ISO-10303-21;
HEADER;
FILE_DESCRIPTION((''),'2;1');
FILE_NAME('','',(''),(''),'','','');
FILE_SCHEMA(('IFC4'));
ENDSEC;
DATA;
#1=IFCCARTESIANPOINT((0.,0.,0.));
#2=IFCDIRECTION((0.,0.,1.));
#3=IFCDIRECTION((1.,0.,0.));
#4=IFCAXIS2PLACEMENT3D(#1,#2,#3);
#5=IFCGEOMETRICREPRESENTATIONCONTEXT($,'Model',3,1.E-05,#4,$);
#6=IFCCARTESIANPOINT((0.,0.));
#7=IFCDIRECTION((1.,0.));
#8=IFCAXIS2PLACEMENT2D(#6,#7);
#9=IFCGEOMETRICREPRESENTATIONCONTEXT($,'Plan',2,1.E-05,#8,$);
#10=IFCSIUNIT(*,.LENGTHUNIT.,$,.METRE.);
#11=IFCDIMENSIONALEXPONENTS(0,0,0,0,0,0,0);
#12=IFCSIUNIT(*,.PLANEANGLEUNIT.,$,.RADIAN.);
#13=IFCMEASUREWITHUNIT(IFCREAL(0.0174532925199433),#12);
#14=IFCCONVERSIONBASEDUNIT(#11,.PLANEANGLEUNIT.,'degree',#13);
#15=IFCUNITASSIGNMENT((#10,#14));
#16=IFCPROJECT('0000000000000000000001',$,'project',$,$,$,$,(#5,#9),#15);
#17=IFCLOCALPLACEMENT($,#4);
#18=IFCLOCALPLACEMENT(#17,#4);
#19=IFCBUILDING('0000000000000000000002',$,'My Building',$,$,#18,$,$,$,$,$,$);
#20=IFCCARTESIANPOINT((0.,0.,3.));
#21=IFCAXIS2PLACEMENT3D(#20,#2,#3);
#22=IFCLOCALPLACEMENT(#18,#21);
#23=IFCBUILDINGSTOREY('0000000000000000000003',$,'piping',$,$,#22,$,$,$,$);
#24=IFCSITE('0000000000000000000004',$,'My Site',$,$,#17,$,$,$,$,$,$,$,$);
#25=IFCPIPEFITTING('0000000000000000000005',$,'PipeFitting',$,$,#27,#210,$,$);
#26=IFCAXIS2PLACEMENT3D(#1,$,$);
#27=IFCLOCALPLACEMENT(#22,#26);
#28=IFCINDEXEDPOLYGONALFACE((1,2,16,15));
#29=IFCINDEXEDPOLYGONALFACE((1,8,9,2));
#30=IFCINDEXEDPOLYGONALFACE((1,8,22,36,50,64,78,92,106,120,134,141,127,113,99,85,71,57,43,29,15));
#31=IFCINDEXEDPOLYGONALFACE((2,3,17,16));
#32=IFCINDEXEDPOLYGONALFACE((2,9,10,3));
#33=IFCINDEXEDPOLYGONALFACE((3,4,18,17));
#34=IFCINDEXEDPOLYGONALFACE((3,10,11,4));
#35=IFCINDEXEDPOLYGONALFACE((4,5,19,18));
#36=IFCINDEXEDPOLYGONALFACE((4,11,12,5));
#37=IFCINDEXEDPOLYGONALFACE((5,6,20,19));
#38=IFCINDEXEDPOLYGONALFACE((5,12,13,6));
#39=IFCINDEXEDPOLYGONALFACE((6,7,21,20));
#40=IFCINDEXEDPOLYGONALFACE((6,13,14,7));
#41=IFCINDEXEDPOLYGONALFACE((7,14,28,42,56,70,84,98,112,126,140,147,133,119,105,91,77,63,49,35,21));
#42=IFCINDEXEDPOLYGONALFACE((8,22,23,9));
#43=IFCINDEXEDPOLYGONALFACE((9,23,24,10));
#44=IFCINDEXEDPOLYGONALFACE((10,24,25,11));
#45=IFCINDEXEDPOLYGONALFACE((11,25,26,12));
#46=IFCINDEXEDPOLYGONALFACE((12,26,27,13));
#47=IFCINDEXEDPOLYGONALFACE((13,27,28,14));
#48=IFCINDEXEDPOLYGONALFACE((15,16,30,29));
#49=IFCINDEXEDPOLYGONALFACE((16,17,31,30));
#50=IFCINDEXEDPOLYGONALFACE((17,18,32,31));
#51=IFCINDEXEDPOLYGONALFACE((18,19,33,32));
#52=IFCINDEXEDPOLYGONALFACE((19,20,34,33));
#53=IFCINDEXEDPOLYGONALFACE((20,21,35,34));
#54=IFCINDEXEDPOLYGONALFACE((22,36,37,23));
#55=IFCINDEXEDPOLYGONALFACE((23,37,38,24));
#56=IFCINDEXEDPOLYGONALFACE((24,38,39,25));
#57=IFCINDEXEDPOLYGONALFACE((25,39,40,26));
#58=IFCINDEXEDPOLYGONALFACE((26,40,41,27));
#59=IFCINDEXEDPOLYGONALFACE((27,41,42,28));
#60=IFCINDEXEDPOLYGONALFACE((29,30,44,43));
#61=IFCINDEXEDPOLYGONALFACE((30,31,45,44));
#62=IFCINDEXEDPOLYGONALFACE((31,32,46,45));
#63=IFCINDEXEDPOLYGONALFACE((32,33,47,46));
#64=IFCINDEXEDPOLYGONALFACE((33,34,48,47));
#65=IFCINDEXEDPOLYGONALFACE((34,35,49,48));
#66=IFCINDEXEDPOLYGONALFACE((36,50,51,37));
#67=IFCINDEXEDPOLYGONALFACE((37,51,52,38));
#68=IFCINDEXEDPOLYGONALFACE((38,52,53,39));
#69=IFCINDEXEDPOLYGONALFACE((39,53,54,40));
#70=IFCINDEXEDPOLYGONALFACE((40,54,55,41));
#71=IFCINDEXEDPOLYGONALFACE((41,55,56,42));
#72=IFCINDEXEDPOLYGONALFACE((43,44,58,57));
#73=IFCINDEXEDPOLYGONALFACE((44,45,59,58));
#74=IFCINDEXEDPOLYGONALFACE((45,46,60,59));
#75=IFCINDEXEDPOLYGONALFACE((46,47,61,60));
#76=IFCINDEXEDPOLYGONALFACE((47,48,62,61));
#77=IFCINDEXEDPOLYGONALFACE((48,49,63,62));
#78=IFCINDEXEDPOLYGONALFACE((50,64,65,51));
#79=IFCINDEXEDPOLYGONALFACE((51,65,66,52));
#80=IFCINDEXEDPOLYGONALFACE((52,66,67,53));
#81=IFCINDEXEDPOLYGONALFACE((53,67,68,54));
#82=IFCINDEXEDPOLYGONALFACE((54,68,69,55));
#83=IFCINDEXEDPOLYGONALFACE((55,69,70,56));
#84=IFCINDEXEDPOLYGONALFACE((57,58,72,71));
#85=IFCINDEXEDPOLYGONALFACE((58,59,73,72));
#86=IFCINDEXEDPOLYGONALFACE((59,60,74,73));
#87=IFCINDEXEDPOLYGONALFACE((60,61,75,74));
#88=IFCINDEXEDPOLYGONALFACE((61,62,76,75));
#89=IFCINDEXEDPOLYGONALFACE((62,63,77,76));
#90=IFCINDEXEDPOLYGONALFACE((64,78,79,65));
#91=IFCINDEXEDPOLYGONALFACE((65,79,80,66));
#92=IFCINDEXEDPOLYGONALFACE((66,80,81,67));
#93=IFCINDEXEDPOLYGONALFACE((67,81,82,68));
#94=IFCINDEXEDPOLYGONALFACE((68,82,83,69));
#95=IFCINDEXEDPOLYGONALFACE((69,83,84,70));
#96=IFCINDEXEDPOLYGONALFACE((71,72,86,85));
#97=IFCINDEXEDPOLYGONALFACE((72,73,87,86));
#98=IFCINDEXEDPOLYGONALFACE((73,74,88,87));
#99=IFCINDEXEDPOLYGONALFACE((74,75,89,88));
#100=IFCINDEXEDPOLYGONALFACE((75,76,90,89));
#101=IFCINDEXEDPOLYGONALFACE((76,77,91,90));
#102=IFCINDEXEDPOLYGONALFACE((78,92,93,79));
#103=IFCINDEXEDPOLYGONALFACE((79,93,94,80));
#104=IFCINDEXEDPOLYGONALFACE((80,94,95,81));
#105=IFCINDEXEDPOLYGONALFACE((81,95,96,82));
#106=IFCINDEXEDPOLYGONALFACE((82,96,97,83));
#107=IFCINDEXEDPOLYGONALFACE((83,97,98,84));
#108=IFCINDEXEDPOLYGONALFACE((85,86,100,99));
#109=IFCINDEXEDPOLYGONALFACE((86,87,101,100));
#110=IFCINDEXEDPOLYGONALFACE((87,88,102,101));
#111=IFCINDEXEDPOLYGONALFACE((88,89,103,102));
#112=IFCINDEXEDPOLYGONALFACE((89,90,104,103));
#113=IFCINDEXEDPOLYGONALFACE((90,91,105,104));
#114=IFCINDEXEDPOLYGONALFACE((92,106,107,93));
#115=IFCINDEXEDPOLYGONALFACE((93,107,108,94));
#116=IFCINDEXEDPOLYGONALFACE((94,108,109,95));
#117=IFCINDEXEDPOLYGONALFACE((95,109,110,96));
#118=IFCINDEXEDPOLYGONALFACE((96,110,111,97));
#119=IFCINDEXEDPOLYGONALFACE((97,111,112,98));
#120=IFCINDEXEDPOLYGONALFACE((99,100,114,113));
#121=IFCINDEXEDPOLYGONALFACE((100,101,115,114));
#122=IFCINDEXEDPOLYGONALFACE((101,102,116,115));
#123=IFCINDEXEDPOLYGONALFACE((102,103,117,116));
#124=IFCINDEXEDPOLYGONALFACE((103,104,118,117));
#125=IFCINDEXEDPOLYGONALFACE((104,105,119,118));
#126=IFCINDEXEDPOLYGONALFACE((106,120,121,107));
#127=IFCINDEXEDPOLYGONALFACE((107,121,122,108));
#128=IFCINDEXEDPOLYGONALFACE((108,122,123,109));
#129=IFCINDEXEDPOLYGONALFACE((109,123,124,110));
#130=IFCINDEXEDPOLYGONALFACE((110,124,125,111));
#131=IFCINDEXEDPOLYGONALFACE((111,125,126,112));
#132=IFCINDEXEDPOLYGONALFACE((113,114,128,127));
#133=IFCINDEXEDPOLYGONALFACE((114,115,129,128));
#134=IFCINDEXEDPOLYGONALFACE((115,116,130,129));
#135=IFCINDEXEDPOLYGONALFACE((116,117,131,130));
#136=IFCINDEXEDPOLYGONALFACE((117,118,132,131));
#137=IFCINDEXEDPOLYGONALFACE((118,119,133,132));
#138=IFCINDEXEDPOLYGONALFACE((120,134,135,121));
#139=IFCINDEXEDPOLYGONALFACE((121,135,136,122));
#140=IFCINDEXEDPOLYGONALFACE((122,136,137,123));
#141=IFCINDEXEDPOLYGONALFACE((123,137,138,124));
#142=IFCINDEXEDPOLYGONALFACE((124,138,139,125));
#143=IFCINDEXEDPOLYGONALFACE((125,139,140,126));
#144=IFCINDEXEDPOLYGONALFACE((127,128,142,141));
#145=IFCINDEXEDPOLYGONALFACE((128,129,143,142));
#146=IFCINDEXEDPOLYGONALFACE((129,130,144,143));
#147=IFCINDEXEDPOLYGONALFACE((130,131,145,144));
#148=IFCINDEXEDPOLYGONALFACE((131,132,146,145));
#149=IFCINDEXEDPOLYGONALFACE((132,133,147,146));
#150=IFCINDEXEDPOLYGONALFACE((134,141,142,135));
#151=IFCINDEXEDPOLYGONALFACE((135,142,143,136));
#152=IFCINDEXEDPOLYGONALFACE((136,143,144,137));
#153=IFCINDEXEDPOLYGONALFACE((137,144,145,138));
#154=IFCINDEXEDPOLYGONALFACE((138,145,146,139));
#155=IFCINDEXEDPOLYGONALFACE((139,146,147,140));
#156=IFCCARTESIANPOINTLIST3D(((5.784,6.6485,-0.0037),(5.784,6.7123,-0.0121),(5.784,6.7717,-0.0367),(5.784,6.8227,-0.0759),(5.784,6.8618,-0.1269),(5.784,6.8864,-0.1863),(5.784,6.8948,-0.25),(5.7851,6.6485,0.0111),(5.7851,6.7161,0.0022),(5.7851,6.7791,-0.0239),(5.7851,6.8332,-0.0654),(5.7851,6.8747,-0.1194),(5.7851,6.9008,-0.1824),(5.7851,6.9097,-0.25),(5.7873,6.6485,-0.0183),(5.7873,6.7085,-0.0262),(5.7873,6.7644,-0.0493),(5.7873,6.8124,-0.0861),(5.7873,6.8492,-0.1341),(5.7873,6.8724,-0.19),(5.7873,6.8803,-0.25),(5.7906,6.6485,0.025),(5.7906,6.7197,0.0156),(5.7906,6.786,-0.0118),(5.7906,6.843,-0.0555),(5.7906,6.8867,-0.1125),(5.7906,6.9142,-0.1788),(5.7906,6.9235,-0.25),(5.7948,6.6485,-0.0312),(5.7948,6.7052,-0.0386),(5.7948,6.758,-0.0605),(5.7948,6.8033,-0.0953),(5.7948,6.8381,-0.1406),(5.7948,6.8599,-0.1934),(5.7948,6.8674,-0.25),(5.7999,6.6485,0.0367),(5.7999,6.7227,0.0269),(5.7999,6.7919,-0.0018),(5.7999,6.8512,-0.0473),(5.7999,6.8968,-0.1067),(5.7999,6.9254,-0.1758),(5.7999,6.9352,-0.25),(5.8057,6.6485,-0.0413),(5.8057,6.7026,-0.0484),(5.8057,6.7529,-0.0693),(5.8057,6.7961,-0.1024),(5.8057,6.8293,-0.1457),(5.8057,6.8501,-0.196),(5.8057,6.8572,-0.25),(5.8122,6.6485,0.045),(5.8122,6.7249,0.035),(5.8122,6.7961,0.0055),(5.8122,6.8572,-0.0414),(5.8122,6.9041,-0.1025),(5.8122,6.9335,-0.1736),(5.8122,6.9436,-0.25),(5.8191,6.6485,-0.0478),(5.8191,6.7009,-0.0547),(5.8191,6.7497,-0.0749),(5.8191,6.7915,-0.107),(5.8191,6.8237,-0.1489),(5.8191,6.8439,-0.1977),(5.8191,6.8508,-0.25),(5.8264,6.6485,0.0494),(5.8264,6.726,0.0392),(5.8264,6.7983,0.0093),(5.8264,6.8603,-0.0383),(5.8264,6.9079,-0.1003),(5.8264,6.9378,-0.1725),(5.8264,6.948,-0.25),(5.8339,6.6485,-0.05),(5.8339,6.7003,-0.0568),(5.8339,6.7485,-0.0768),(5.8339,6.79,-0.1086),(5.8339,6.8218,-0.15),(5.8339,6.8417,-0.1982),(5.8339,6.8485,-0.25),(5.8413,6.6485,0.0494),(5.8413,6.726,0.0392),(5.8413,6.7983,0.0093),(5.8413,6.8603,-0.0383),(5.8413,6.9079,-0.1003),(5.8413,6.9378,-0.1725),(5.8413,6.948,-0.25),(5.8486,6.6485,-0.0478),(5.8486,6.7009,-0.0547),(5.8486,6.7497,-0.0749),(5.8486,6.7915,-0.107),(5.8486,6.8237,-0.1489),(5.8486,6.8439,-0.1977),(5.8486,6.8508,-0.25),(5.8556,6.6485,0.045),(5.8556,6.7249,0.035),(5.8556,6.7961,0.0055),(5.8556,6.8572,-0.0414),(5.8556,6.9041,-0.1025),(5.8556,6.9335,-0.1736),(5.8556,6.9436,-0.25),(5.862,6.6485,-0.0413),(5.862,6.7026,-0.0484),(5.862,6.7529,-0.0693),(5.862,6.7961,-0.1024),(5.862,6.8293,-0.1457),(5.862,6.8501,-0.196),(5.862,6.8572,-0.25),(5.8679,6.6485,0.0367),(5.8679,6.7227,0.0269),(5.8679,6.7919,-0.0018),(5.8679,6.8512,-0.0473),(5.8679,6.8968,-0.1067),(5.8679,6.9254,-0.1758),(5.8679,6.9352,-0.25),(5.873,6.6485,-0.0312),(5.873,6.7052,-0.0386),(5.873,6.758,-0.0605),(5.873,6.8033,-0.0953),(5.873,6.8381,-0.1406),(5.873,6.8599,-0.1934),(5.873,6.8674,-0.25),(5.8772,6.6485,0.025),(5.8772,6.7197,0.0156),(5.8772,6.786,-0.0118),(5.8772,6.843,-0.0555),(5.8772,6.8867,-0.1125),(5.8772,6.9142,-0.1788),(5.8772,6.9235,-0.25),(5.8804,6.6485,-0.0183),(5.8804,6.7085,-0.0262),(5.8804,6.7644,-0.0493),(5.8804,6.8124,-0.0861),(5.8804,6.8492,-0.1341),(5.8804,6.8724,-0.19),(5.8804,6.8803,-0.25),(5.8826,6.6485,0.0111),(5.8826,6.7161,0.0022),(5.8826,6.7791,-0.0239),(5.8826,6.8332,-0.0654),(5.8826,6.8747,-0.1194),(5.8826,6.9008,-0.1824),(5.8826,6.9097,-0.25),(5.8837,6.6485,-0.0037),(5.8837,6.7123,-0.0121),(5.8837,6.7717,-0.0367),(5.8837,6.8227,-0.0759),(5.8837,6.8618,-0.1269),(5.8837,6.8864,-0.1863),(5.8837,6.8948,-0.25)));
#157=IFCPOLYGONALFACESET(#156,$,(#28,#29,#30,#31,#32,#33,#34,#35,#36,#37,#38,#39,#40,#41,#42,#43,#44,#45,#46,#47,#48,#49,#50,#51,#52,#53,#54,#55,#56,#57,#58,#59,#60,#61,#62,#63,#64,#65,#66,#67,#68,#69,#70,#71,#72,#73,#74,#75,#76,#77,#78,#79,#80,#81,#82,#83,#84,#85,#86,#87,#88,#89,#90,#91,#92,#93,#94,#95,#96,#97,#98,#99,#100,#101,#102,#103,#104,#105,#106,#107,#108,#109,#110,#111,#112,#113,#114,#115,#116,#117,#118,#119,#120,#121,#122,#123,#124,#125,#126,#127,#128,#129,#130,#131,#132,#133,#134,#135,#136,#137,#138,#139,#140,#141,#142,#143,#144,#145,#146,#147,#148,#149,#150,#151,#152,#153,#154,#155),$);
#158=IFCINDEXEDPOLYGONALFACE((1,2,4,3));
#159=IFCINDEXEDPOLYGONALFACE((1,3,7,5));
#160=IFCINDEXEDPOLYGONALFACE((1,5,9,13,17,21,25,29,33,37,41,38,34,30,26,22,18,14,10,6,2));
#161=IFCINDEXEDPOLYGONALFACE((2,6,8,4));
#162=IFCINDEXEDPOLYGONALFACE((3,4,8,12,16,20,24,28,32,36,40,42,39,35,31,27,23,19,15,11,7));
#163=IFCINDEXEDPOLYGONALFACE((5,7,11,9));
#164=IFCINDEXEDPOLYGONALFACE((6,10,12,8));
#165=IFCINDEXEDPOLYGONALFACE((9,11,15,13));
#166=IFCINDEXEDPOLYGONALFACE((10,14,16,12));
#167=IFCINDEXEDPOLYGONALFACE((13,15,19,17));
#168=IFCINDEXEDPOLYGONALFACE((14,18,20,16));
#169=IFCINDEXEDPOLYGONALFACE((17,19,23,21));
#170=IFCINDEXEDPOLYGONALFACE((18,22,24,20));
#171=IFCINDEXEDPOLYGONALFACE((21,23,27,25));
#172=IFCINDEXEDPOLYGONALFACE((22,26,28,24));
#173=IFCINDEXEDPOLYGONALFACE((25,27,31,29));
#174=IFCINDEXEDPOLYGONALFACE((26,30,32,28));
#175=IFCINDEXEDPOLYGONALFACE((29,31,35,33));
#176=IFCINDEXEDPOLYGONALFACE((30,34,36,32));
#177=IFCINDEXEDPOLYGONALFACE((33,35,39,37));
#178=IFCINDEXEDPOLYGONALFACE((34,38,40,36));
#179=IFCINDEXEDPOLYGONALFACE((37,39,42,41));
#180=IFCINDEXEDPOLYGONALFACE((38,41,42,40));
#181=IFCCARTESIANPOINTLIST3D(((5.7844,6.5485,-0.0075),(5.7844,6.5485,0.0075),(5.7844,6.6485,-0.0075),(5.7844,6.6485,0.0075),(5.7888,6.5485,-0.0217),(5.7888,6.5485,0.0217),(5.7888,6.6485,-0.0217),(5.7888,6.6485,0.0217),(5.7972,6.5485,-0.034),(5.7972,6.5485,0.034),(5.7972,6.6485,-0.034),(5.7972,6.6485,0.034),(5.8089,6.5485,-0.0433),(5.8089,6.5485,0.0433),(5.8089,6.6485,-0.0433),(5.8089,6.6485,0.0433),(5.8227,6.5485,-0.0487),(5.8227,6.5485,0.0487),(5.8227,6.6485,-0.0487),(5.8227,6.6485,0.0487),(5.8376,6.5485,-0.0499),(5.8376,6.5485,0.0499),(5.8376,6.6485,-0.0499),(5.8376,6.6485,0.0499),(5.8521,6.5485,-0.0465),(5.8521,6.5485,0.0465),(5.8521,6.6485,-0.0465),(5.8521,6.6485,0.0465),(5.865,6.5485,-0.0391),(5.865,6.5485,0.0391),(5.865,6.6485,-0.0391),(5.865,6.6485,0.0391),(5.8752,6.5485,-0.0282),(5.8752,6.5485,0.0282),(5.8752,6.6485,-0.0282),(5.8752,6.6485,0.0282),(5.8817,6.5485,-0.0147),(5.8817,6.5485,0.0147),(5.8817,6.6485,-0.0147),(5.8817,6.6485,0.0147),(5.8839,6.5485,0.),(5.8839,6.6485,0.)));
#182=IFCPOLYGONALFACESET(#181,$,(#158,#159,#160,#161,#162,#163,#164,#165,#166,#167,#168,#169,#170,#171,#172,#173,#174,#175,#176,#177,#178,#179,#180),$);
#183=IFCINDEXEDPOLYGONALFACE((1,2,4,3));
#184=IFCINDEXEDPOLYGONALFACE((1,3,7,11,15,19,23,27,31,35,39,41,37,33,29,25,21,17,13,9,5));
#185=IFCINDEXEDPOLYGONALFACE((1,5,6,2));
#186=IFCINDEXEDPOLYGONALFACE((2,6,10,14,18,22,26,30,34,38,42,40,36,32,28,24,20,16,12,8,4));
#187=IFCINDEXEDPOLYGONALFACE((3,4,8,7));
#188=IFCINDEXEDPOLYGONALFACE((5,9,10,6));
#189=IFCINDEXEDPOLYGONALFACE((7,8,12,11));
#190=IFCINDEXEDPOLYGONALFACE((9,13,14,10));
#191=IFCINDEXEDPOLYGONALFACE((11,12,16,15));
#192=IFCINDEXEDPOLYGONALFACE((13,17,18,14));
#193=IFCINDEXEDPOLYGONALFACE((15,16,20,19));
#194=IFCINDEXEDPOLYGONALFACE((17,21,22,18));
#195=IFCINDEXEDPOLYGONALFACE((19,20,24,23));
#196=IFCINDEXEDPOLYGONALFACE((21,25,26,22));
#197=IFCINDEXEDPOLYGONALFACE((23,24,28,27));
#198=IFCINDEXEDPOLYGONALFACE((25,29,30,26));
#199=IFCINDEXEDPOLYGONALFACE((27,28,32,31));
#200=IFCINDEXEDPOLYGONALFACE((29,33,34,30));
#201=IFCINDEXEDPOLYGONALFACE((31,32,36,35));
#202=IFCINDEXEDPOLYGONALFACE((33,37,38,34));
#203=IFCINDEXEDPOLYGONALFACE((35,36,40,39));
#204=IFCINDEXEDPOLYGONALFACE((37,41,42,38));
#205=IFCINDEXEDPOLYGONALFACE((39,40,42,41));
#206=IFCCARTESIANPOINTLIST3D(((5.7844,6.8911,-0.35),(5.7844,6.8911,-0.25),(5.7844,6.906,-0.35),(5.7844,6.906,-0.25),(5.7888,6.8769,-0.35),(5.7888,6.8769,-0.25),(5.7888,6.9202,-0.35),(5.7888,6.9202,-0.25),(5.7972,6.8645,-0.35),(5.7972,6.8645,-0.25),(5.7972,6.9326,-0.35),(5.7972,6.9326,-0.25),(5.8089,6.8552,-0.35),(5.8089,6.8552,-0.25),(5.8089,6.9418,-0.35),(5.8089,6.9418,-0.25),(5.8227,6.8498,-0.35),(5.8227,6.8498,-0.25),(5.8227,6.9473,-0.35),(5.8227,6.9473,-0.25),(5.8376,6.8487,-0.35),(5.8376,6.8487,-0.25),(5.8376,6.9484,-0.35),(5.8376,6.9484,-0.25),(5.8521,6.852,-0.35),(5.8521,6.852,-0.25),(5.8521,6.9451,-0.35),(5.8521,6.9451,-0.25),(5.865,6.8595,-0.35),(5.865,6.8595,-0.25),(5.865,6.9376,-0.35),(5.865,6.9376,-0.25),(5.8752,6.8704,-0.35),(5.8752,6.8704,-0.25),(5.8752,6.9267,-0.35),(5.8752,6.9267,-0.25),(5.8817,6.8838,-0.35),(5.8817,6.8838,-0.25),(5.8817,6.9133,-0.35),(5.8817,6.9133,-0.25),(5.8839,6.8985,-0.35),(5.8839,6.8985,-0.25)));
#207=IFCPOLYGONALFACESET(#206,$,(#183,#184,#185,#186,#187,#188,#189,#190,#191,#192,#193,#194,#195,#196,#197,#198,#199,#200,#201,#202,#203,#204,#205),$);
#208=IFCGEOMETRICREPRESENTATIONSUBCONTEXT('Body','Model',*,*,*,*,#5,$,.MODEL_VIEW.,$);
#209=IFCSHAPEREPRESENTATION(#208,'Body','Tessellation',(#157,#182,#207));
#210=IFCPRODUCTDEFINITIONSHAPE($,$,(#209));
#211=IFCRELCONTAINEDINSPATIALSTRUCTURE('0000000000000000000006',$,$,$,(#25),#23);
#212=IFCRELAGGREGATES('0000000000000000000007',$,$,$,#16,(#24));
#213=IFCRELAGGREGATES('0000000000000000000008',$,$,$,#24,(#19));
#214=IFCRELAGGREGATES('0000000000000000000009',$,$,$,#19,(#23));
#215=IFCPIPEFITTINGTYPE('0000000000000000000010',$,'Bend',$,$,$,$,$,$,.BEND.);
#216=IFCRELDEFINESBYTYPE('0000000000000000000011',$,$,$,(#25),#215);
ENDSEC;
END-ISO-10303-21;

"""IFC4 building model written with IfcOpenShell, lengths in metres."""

from ifc_helpers import new_model, entity, si_unit, converted_unit, frame, origin_with_axes, origin_2d_with_axis, place, context, subcontext, project, spatial, circle, extrude, source, transform, mapped, type_object, type_shapes, element, save


model = new_model("IFC4")

# Units and contexts
model_context = context("Model", 3, precision=1e-05, world=origin_with_axes())
plan_context = context("Plan", 2, precision=1e-05, world=origin_2d_with_axis())
body_context = subcontext(model_context, "Body", "Model", "MODEL_VIEW")
ifc_project = project(units=[si_unit("LENGTHUNIT", "METRE"), converted_unit("PLANEANGLEUNIT", "degree", entity("IfcReal", 0.0174532925199433), si_unit("PLANEANGLEUNIT", "RADIAN"), dimensions=[0, 0, 0, 0, 0, 0, 0])], contexts=[model_context, plan_context])

# Site, building, storey
site_placement = place(None, origin_with_axes())
site = spatial("IfcSite", under=ifc_project, at=site_placement, Name="My Site")
building_placement = place(site_placement, origin_with_axes())
building = spatial("IfcBuilding", under=site, at=building_placement, Name="My Building")
storey_placement = place(building_placement, frame((0.0, 0.0, 3.0), z_axis=(0.0, 0.0, 1.0), x_axis=(1.0, 0.0, 0.0)))
storey = spatial("IfcBuildingStorey", under=building, at=storey_placement, Name="piping")

# Pipe fitting
pipe_fitting_type = type_object("IfcPipeFittingType", Name="Bend", PredefinedType="BEND")
shared_shape = source(origin_with_axes(), body_context, "Body", "SolidModel", [
    entity("IfcSweptDiskSolid", entity("IfcIndexedPolyCurve", entity("IfcCartesianPointList3D", [[0.0, 0.0, -0.1], [0.0, -0.0732, -0.2768], [0.0, -0.25, -0.35]]), [entity("IfcArcIndex", [1, 2, 3])]), 0.05),
    extrude(circle(Radius=0.05), origin_with_axes(), (0.0, 0.0, -1.0), 0.1),
    extrude(circle(Radius=0.05), frame((0.0, -0.25, -0.35), z_axis=(0.0, -1.0, 0.0), x_axis=(1.0, 0.0, 0.0)), (0.0, 0.0, 1.0), 0.1),
])
type_shapes(pipe_fitting_type, [shared_shape])
for number, where, z_axis, x_axis, name in (
    (1, (5.8339, 6.5485, 0.0), (0.0, -1.0, 0.0), (1.0, 0.0, 0.0), "PipeFitting"),
):
    element("IfcPipeFitting", number, at=place(storey_placement, frame(where, z_axis=z_axis, x_axis=x_axis)), inside=storey, type_object=pipe_fitting_type, Name=name, context=body_context, shape_type="MappedRepresentation", body=[
        mapped(shared_shape, transform((0.0, 0.0, 0.0), x_axis=(1.0, 0.0, 0.0), y_axis=(0.0, 1.0, 0.0), z_axis=(0.0, 0.0, 1.0), scale=1.0)),
    ])

save(model, "model.ifc")
